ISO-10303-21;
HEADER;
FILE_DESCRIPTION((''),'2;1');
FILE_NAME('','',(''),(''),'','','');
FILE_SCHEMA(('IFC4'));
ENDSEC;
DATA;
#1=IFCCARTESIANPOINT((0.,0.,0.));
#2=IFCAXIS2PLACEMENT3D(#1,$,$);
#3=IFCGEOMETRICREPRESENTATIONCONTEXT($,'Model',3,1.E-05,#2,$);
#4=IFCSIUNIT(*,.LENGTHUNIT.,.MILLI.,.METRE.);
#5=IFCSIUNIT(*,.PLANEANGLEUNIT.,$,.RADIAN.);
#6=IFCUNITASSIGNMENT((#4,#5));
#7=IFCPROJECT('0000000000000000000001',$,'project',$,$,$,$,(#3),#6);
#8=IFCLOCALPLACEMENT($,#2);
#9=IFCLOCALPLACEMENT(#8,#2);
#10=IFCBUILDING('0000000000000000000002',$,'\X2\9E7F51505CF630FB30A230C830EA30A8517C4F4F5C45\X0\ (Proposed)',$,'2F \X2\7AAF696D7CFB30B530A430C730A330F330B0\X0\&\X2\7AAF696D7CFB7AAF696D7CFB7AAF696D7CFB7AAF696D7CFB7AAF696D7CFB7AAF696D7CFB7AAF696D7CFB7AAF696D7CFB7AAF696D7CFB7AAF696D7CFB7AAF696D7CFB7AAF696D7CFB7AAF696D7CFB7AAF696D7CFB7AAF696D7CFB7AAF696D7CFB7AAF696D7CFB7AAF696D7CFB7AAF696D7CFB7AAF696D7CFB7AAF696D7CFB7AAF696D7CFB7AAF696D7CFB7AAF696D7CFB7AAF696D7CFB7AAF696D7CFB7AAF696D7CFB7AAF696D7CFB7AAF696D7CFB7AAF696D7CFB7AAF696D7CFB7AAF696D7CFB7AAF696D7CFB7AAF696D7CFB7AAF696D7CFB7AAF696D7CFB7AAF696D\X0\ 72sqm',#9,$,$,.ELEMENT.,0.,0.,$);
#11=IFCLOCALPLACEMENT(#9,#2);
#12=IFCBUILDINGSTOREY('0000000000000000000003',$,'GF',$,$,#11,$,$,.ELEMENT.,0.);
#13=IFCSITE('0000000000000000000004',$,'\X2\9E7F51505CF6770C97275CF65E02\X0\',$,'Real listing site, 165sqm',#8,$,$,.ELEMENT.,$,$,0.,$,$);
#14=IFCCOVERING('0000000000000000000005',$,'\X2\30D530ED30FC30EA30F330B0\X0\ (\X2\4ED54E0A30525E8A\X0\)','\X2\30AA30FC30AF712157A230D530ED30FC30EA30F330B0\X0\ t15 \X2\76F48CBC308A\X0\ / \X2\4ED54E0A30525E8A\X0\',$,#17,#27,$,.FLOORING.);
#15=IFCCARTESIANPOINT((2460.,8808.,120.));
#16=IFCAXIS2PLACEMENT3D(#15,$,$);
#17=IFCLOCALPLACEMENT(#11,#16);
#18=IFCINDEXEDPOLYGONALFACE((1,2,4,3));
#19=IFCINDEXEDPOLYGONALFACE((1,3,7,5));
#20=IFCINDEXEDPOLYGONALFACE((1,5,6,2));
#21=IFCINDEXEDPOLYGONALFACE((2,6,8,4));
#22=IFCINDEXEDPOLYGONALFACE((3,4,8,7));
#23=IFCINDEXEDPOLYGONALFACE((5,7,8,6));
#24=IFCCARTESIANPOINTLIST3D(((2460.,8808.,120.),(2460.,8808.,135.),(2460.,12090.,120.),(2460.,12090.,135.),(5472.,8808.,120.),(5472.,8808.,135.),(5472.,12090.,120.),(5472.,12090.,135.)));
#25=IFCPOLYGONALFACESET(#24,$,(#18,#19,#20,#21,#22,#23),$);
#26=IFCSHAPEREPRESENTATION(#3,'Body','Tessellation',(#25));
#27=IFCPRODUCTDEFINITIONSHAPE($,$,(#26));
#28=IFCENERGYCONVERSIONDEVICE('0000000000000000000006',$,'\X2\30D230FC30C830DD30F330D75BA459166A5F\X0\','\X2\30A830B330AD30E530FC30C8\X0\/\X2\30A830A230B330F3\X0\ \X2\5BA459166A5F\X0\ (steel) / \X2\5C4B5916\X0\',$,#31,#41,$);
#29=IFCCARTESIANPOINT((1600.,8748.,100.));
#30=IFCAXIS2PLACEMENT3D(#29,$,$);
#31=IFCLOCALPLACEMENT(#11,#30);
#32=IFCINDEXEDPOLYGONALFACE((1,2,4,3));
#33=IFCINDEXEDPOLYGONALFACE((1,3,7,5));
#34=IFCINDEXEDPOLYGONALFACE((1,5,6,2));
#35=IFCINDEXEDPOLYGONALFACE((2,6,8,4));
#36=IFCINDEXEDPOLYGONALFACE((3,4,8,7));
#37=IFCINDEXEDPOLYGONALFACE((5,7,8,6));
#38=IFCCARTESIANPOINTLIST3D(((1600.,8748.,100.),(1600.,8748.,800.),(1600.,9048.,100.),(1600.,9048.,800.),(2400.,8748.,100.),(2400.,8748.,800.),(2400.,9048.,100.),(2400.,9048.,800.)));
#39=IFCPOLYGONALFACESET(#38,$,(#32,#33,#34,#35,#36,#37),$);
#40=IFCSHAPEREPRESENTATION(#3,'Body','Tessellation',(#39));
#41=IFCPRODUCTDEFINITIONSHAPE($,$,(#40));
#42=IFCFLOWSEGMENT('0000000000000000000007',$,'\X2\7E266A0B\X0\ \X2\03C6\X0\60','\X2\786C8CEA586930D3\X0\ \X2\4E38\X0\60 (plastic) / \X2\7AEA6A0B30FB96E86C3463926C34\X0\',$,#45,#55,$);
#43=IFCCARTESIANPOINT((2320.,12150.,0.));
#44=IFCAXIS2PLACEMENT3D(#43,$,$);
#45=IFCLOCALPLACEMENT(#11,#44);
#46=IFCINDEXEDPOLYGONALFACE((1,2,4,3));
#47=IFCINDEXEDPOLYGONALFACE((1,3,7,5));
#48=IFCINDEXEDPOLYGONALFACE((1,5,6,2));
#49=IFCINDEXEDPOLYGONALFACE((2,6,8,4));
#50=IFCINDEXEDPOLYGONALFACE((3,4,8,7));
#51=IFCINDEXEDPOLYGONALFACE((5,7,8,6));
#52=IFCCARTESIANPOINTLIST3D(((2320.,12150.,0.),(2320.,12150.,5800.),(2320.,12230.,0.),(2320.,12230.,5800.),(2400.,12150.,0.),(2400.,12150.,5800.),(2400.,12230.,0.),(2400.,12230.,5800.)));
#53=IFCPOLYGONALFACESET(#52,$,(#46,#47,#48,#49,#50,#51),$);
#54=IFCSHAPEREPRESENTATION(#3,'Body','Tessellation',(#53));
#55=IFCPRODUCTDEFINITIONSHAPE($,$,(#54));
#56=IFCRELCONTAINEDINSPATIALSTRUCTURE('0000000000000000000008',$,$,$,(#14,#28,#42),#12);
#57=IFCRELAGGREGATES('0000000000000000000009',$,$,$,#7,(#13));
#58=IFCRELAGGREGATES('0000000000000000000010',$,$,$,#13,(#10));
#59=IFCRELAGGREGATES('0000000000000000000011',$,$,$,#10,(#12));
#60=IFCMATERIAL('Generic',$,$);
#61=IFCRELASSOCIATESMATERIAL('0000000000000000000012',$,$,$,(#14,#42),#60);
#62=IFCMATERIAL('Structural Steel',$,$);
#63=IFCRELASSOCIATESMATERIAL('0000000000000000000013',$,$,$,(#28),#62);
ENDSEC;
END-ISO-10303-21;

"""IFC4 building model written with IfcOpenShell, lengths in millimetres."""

from ifc_helpers import new_model, si_unit, frame, frame_2d, origin, place, context, project, spatial, rectangle, extrude, material, element, save


model = new_model("IFC4")

# Units and contexts
model_context = context("Model", 3, precision=1e-05, world=origin())
ifc_project = project(units=[si_unit("LENGTHUNIT", "METRE", prefix="MILLI"), si_unit("PLANEANGLEUNIT", "RADIAN")], contexts=[model_context])

# Site, building, storey
site_placement = place(None, origin())
site = spatial("IfcSite", under=ifc_project, at=site_placement, Name="鹿児島県霧島市", ObjectType="Real listing site, 165sqm", CompositionType="ELEMENT", RefElevation=0.0)
building_placement = place(site_placement, origin())
building = spatial("IfcBuilding", under=site, at=building_placement, Name="鹿児島・アトリエ兼住居 (Proposed)", ObjectType="2F 窯業系サイディング&窯業系窯業系窯業系窯業系窯業系窯業系窯業系窯業系窯業系窯業系窯業系窯業系窯業系窯業系窯業系窯業系窯業系窯業系窯業系窯業系窯業系窯業系窯業系窯業系窯業系窯業系窯業系窯業系窯業系窯業系窯業系窯業系窯業系窯業系窯業系窯業系窯業 72sqm", CompositionType="ELEMENT", ElevationOfRefHeight=0.0, ElevationOfTerrain=0.0)
storey_placement = place(building_placement, origin())
storey = spatial("IfcBuildingStorey", under=building, at=storey_placement, Name="GF", CompositionType="ELEMENT", Elevation=0.0)

# Covering
ifc_material_1 = material(Name="Generic")
covering_placement = place(storey_placement, frame((2460.0, 8808.0, 120.0)))
element("IfcCovering", 1, at=covering_placement, inside=storey, material=ifc_material_1, Name="フローリング (仕上げ床)", Description="オーク無垢フローリング t15 直貼り / 仕上げ床", PredefinedType="FLOORING", context=model_context, shape_type="SweptSolid", body=[
    extrude(rectangle(XDim=3012.0, YDim=3282.0, at=frame_2d((1506.0, 1641.0))), frame((2460.0, 8808.0, 120.0)), (0.0, 0.0, 1.0), 15.0),
])

# Energy conversion device
ifc_material_2 = material(Name="Structural Steel")
energy_conversion_device_placement = place(storey_placement, frame((1600.0, 8748.0, 100.0)))
element("IfcEnergyConversionDevice", 2, at=energy_conversion_device_placement, inside=storey, material=ifc_material_2, Name="ヒートポンプ室外機", Description="エコキュート/エアコン 室外機 (steel) / 屋外", context=model_context, shape_type="SweptSolid", body=[
    extrude(rectangle(XDim=800.0, YDim=300.0, at=frame_2d((400.0, 150.0))), frame((1600.0, 8748.0, 100.0)), (0.0, 0.0, 1.0), 700.0),
])

# Flow segment
flow_segment_placement = place(storey_placement, frame((2320.0, 12150.0, 0.0)))
element("IfcFlowSegment", 3, at=flow_segment_placement, inside=storey, material=ifc_material_1, Name="縦樋 φ60", Description="硬質塩ビ 丸60 (plastic) / 竪樋・雨水排水", context=model_context, shape_type="SweptSolid", body=[
    extrude(rectangle(XDim=80.0, YDim=80.0, at=frame_2d((40.0, 40.0))), frame((2320.0, 12150.0, 0.0)), (0.0, 0.0, 1.0), 5800.0),
])

save(model, "model.ifc")
